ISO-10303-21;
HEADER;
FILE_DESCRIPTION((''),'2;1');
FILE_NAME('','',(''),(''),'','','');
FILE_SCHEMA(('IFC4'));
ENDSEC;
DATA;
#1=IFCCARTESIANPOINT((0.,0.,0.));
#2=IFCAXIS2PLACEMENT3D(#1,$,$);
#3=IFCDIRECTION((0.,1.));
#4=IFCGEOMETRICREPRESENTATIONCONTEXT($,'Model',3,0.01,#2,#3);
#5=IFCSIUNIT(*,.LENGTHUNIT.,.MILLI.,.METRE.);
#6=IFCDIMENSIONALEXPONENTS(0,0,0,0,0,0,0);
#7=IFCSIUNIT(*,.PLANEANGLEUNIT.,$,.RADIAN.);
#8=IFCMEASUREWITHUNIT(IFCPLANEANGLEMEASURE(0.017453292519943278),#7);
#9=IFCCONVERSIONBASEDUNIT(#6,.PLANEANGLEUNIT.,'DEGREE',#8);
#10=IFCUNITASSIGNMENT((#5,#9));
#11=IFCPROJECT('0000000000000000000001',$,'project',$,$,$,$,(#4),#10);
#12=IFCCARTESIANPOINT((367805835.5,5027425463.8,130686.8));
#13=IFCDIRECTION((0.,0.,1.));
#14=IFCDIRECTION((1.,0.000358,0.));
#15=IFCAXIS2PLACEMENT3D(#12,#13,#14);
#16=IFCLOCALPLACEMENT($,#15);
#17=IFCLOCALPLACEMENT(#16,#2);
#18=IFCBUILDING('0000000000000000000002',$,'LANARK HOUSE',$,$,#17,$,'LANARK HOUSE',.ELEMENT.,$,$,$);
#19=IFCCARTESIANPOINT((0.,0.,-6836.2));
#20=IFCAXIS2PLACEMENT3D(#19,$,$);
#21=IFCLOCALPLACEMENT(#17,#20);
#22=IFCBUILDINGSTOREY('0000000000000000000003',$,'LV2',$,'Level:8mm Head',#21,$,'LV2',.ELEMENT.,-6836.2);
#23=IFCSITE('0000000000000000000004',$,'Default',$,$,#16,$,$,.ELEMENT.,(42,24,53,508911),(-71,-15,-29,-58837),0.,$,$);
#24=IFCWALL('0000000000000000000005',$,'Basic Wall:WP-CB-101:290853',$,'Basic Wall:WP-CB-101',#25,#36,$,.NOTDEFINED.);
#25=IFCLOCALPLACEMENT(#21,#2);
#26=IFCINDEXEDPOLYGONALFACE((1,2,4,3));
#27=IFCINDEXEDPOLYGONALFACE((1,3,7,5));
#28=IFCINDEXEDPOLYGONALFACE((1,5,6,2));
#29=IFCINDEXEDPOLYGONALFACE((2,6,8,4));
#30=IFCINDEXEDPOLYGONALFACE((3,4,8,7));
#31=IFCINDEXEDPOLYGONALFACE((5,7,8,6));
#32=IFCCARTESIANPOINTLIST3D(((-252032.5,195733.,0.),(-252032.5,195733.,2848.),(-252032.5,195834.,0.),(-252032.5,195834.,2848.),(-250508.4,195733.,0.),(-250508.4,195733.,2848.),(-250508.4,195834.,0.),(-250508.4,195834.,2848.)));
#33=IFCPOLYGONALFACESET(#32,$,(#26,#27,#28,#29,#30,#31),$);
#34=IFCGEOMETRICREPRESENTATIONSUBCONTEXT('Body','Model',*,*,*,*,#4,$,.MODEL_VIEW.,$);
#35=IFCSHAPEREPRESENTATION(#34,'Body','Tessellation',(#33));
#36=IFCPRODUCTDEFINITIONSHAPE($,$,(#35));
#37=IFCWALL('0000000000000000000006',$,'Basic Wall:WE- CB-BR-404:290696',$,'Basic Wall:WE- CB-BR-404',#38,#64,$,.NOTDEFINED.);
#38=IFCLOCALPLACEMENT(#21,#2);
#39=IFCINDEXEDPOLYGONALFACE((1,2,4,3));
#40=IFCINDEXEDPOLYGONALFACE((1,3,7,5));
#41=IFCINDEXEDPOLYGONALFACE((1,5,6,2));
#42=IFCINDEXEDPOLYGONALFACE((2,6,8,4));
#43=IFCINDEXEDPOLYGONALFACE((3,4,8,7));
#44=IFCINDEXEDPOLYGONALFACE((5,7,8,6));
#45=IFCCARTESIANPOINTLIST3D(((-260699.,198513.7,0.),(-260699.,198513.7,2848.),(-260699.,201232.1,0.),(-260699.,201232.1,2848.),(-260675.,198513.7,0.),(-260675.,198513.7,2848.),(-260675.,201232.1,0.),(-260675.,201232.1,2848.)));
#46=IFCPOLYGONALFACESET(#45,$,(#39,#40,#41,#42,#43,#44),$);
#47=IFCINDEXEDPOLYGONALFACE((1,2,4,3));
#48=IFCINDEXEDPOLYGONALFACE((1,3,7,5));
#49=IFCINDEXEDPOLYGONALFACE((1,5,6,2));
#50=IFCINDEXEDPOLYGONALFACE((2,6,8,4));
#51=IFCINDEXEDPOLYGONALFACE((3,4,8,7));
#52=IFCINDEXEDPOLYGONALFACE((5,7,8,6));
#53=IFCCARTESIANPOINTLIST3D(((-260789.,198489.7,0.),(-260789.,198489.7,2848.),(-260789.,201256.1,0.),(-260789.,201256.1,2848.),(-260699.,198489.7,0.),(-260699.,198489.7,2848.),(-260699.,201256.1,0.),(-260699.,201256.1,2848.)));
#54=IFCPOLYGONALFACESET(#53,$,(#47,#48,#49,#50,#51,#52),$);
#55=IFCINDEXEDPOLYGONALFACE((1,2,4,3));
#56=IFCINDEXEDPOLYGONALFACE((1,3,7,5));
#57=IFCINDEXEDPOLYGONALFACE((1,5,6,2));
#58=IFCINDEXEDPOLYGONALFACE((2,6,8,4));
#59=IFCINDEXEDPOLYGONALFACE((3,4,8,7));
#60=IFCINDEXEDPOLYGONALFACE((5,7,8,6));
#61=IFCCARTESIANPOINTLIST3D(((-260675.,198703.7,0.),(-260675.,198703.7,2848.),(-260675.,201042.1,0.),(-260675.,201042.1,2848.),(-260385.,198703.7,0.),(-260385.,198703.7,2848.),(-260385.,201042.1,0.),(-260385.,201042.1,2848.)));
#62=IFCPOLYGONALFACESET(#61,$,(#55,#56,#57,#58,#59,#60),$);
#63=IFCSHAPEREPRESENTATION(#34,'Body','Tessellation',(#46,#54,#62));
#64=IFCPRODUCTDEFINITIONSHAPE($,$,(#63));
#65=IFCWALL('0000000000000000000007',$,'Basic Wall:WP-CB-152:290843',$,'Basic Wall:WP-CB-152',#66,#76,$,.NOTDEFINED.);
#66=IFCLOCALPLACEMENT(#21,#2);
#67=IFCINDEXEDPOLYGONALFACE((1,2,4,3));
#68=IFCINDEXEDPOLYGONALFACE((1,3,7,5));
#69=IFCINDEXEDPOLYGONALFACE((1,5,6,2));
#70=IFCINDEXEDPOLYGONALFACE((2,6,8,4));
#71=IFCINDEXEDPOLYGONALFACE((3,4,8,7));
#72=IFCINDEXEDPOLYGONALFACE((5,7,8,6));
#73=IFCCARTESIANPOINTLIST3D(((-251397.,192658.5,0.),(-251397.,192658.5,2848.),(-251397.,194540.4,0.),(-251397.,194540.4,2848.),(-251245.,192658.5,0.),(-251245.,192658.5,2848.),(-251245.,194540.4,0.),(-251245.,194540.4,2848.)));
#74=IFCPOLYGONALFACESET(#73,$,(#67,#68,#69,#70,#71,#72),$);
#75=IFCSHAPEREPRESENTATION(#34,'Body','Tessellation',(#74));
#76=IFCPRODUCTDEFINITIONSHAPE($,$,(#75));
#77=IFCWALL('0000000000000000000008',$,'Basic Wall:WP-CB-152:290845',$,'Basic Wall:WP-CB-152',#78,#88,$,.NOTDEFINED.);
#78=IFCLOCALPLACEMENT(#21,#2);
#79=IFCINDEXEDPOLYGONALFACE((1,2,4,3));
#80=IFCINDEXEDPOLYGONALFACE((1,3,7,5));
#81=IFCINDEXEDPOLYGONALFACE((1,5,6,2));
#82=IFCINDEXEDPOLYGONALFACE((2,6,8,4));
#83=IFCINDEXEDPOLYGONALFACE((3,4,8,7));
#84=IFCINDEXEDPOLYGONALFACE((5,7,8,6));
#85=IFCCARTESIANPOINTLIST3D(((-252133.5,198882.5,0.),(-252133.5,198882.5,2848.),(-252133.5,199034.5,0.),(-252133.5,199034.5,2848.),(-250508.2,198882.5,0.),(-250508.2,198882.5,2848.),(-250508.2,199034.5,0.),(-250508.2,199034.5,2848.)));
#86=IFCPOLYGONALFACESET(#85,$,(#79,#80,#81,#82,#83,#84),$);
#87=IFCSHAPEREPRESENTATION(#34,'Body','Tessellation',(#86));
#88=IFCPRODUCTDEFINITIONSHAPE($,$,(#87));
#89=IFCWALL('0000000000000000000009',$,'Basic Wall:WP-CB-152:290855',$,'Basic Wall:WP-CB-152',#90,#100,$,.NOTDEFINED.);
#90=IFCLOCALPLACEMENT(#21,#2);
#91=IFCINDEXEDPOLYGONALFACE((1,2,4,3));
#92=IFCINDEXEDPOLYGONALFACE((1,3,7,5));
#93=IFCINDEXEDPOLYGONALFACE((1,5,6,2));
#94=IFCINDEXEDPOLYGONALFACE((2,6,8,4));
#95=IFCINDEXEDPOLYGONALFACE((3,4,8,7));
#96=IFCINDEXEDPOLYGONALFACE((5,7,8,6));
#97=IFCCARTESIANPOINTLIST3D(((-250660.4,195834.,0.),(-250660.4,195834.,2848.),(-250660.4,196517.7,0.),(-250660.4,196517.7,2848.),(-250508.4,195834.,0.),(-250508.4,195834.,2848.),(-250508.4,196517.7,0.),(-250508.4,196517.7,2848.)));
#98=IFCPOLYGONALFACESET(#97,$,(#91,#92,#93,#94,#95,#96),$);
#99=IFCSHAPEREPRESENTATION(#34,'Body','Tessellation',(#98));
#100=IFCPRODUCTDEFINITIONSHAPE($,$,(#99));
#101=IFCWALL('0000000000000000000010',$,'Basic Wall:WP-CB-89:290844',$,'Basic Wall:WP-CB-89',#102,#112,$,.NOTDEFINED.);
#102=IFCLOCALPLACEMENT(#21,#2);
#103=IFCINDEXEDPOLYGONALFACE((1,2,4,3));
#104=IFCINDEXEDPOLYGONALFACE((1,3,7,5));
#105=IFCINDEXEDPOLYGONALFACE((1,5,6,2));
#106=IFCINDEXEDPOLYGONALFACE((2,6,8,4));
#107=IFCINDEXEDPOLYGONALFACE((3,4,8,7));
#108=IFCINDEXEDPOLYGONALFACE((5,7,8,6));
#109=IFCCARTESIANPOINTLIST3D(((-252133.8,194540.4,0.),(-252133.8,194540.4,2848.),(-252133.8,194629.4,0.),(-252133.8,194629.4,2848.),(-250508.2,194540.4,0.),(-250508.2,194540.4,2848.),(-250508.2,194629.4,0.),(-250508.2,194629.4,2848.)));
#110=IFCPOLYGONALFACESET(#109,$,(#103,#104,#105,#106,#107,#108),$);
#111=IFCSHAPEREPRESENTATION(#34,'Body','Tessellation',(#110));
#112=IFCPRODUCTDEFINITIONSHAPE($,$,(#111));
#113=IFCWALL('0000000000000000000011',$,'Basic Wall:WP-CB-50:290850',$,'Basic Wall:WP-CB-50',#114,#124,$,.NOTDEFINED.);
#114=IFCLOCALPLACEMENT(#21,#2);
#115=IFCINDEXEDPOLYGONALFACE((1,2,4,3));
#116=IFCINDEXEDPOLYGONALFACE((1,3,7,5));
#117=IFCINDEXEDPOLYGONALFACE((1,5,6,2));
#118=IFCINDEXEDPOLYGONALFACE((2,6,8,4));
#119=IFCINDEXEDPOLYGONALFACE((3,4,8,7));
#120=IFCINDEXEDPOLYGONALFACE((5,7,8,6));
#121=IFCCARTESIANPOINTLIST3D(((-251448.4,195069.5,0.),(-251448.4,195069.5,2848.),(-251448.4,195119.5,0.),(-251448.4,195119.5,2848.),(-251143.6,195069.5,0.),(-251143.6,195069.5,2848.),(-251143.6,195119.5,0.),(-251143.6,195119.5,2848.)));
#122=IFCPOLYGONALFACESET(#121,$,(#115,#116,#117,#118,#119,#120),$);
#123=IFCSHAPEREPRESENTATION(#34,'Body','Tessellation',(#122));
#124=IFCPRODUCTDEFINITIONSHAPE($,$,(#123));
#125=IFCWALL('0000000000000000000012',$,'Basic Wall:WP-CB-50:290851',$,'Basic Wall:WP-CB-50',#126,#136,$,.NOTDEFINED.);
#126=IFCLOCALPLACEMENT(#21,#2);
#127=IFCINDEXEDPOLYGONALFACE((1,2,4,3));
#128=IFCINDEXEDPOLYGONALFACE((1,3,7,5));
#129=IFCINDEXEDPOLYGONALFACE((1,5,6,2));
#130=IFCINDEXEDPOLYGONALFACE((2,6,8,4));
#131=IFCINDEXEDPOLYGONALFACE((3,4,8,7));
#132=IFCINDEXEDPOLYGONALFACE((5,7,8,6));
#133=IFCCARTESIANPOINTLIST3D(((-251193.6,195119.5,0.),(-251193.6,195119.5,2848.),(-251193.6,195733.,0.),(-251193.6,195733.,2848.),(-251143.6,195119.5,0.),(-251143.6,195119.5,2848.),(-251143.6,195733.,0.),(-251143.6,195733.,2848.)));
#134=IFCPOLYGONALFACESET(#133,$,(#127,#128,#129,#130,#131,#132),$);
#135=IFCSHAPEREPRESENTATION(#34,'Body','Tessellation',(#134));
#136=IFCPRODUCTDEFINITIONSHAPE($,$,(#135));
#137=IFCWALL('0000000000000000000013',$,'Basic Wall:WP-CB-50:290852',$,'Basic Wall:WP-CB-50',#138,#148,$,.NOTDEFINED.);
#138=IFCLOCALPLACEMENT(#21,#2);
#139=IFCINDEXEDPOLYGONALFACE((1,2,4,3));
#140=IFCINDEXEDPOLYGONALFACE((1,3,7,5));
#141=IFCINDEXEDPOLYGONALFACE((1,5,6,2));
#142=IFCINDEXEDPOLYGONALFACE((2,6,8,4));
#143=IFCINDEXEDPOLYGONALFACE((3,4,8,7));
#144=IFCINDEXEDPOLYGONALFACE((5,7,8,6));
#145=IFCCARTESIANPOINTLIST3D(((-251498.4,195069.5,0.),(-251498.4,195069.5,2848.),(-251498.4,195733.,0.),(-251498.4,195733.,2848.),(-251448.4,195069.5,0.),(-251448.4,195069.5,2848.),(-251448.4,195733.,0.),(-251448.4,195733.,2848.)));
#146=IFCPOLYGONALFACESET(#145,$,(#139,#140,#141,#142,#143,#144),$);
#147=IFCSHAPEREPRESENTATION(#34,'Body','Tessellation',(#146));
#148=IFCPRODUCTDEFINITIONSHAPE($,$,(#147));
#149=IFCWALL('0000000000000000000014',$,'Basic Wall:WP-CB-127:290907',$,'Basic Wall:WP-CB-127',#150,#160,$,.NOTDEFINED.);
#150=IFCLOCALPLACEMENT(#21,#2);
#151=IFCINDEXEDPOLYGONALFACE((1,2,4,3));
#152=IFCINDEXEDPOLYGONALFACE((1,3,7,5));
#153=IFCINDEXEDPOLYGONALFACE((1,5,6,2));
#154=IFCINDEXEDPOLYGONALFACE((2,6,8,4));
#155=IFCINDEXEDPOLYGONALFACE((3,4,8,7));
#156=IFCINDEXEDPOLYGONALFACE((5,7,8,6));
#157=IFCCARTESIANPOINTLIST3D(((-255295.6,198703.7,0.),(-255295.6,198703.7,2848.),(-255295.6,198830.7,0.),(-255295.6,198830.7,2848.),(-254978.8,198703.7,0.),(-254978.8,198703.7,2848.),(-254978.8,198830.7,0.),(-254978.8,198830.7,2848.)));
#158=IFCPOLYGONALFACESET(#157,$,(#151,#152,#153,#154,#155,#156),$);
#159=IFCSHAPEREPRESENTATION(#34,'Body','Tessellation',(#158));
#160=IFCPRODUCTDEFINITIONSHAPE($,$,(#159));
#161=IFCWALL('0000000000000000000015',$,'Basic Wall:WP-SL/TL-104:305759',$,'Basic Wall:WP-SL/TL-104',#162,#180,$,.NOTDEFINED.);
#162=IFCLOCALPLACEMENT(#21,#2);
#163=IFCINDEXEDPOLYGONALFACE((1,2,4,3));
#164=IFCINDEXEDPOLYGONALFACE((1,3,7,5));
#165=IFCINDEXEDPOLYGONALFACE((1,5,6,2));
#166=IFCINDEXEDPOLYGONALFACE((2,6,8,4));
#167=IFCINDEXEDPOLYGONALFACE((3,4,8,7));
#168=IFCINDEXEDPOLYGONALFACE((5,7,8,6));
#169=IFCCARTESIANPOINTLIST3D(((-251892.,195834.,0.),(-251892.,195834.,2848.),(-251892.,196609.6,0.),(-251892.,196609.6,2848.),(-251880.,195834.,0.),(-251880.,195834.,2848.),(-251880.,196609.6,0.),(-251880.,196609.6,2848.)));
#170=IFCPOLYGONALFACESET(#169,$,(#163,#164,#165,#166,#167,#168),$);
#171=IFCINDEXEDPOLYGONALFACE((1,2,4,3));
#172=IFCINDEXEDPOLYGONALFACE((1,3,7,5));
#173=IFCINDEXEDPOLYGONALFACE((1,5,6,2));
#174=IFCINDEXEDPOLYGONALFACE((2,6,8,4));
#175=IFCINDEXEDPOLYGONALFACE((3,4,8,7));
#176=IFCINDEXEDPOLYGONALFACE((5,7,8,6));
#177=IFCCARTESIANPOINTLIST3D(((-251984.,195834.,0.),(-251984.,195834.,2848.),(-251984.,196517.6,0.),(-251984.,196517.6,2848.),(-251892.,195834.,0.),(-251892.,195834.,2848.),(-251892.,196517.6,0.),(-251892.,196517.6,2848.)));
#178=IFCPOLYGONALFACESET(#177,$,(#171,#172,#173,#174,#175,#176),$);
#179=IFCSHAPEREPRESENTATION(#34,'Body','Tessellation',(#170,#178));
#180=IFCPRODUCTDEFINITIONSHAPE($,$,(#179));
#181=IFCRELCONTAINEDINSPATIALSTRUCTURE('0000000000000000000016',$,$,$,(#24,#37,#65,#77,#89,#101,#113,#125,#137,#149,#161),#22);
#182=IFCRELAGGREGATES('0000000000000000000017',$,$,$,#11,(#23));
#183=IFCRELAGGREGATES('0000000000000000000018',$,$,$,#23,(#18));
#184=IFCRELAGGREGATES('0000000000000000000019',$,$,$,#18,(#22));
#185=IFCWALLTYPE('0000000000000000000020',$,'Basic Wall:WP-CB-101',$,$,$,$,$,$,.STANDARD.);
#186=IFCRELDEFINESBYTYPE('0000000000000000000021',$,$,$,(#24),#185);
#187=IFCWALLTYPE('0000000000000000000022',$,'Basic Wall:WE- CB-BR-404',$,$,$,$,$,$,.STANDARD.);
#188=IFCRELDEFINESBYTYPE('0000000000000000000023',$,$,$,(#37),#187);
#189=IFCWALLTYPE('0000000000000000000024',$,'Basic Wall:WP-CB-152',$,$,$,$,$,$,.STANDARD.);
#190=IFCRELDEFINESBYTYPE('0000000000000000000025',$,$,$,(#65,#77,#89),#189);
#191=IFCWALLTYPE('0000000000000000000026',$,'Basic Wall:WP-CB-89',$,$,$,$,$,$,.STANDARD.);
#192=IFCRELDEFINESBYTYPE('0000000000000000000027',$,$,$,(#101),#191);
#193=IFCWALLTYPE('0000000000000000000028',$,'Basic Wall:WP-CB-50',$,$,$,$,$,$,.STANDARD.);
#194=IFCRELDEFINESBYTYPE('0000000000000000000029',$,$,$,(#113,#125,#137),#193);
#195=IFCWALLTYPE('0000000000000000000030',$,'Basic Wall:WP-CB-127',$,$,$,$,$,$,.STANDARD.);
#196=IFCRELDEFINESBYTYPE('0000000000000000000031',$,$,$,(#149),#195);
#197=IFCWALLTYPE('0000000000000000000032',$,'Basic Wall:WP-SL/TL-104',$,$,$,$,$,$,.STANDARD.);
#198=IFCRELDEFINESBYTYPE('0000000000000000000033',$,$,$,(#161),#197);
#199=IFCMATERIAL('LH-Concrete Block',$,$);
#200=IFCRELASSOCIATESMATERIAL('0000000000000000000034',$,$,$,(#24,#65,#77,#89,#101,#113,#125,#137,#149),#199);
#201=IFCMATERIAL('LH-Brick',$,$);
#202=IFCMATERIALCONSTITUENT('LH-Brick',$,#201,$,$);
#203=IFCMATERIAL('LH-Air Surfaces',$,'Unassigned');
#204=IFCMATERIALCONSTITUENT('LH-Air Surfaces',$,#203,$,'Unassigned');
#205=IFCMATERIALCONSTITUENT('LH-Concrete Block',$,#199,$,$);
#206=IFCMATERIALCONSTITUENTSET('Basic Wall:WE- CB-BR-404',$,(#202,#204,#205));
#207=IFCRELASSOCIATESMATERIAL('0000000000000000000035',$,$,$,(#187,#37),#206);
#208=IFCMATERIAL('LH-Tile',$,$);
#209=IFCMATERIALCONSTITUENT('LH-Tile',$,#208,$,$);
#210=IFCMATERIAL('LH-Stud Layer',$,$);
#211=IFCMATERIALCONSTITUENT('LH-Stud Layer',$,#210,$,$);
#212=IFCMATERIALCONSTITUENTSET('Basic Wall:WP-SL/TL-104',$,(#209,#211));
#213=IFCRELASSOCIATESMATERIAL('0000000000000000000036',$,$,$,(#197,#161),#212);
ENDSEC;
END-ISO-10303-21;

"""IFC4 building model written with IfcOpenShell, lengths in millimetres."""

from ifc_helpers import new_model, entity, si_unit, converted_unit, direction, frame, origin, place, context, subcontext, project, spatial, indexed_curve, outline, extrude, material, constituent, constituent_set, type_object, element, save


model = new_model("IFC4")

# Units and contexts
model_context = context("Model", 3, precision=0.01, world=origin(), true_north=direction((0.0, 1.0)))
body_context = subcontext(model_context, "Body", "Model", "MODEL_VIEW")
ifc_project = project(units=[si_unit("LENGTHUNIT", "METRE", prefix="MILLI"), converted_unit("PLANEANGLEUNIT", "DEGREE", entity("IfcPlaneAngleMeasure", 0.017453292519943278), si_unit("PLANEANGLEUNIT", "RADIAN"), dimensions=[0, 0, 0, 0, 0, 0, 0])], contexts=[model_context])

# Site, building, storey
site_placement = place(None, frame((367805835.5, 5027425463.8, 130686.8), z_axis=(0.0, 0.0, 1.0), x_axis=(1.0, 0.000358, 0.0)))
site = spatial("IfcSite", under=ifc_project, at=site_placement, Name="Default", CompositionType="ELEMENT", RefLatitude=(42, 24, 53, 508911), RefLongitude=(-71, -15, -29, -58837), RefElevation=0.0)
building_placement = place(site_placement, origin())
building = spatial("IfcBuilding", under=site, at=building_placement, Name="LANARK HOUSE", LongName="LANARK HOUSE", CompositionType="ELEMENT")
storey_placement = place(building_placement, frame((0.0, 0.0, -6836.2)))
storey = spatial("IfcBuildingStorey", under=building, at=storey_placement, Name="LV2", ObjectType="Level:8mm Head", LongName="LV2", CompositionType="ELEMENT", Elevation=-6836.2)

# Walls
ifc_material_1 = material(Name="LH-Brick")
ifc_material_2 = material(Name="LH-Air Surfaces", Category="Unassigned")
ifc_material_3 = material(Name="LH-Concrete Block")
wall_type_1 = type_object("IfcWallType", Name="Basic Wall:WP-CB-101", PredefinedType="STANDARD")
wall_1_placement = place(storey_placement, frame((-252032.5, 195783.5, 0.0)))
element("IfcWall", 1, at=wall_1_placement, inside=storey, type_object=wall_type_1, material=ifc_material_3, Name="Basic Wall:WP-CB-101:290853", ObjectType="Basic Wall:WP-CB-101", PredefinedType="NOTDEFINED", context=body_context, shape_type="SweptSolid", body=[
    extrude(outline(indexed_curve([(1524.1, 50.5), (0.0, 50.5), (0.0, -50.5), (1524.1, -50.5), (1524.1, 50.5)], self_intersect=False)), origin(), (0.0, 0.0, 1.0), 2848.0),
])
ifc_constituent_1 = constituent(ifc_material_1, Name="LH-Brick")
ifc_constituent_2 = constituent(ifc_material_2, Name="LH-Air Surfaces", Category="Unassigned")
ifc_constituent_3 = constituent(ifc_material_3, Name="LH-Concrete Block")
ifc_constituent_set_1 = constituent_set(constituents=[ifc_constituent_1, ifc_constituent_2, ifc_constituent_3], Name="Basic Wall:WE- CB-BR-404")
wall_type_2 = type_object("IfcWallType", Name="Basic Wall:WE- CB-BR-404", PredefinedType="STANDARD", material=ifc_constituent_set_1)
wall_2_placement = place(storey_placement, frame((-260587.0, 198703.7, 0.0), z_axis=(0.0, 0.0, 1.0), x_axis=(0.0, 1.0, 0.0)))
element("IfcWall", 2, at=wall_2_placement, inside=storey, type_object=wall_type_2, material=ifc_constituent_set_1, Name="Basic Wall:WE- CB-BR-404:290696", ObjectType="Basic Wall:WE- CB-BR-404", PredefinedType="NOTDEFINED", context=body_context, shape_type="SweptSolid", body=[
    extrude(outline(indexed_curve([(-1359.2, -12.0), (1359.2, -12.0), (1359.2, 12.0), (-1359.2, 12.0), (-1359.2, -12.0)], self_intersect=False)), frame((1169.2, 100.0, 0.0)), (0.0, 0.0, 1.0), 2848.0),
    extrude(outline(indexed_curve([(-45.0, -1383.2), (45.0, -1383.2), (45.0, 1383.2), (-45.0, 1383.2), (-45.0, -1383.2)], self_intersect=False)), frame((1169.2, 157.0, 0.0), z_axis=(0.0, 0.0, 1.0), x_axis=(0.0, -1.0, 0.0)), (0.0, 0.0, 1.0), 2848.0),
    extrude(outline(indexed_curve([(-145.0, -1169.2), (145.0, -1169.2), (145.0, 1169.2), (-145.0, 1169.2), (-145.0, -1169.2)], self_intersect=False)), frame((1169.2, -57.0, 0.0), z_axis=(0.0, 0.0, 1.0), x_axis=(0.0, 1.0, 0.0)), (0.0, 0.0, 1.0), 2848.0),
])
wall_type_3 = type_object("IfcWallType", Name="Basic Wall:WP-CB-152", PredefinedType="STANDARD")
wall_3_placement = place(storey_placement, frame((-251321.0, 194540.4, 0.0), z_axis=(0.0, 0.0, 1.0), x_axis=(0.0, -1.0, 0.0)))
element("IfcWall", 3, at=wall_3_placement, inside=storey, type_object=wall_type_3, material=ifc_material_3, Name="Basic Wall:WP-CB-152:290843", ObjectType="Basic Wall:WP-CB-152", PredefinedType="NOTDEFINED", context=body_context, shape_type="SweptSolid", body=[
    extrude(outline(indexed_curve([(1881.9, 76.0), (0.0, 76.0), (0.0, -76.0), (1881.9, -76.0), (1881.9, 76.0)], self_intersect=False)), origin(), (0.0, 0.0, 1.0), 2848.0),
])
wall_4_placement = place(storey_placement, frame((-252133.5, 198958.5, 0.0)))
element("IfcWall", 4, at=wall_4_placement, inside=storey, type_object=wall_type_3, material=ifc_material_3, Name="Basic Wall:WP-CB-152:290845", ObjectType="Basic Wall:WP-CB-152", PredefinedType="NOTDEFINED", context=body_context, shape_type="SweptSolid", body=[
    extrude(outline(indexed_curve([(1625.3, 76.0), (0.0, 76.0), (0.0, -76.0), (1625.3, -76.0), (1625.3, 76.0)], self_intersect=False)), origin(), (0.0, 0.0, 1.0), 2848.0),
])
wall_5_placement = place(storey_placement, frame((-250584.4, 196517.7, 0.0), z_axis=(0.0, 0.0, 1.0), x_axis=(0.0, -1.0, 0.0)))
element("IfcWall", 5, at=wall_5_placement, inside=storey, type_object=wall_type_3, material=ifc_material_3, Name="Basic Wall:WP-CB-152:290855", ObjectType="Basic Wall:WP-CB-152", PredefinedType="NOTDEFINED", context=body_context, shape_type="SweptSolid", body=[
    extrude(outline(indexed_curve([(683.7, 76.0), (0.0, 76.0), (0.0, -76.0), (683.7, -76.0), (683.7, 76.0)], self_intersect=False)), origin(), (0.0, 0.0, 1.0), 2848.0),
])
wall_type_4 = type_object("IfcWallType", Name="Basic Wall:WP-CB-89", PredefinedType="STANDARD")
wall_6_placement = place(storey_placement, frame((-252133.8, 194584.9, 0.0)))
element("IfcWall", 6, at=wall_6_placement, inside=storey, type_object=wall_type_4, material=ifc_material_3, Name="Basic Wall:WP-CB-89:290844", ObjectType="Basic Wall:WP-CB-89", PredefinedType="NOTDEFINED", context=body_context, shape_type="SweptSolid", body=[
    extrude(outline(indexed_curve([(1625.6, 44.5), (0.0, 44.5), (0.0, -44.5), (1625.6, -44.5), (1625.6, 44.5)], self_intersect=False)), origin(), (0.0, 0.0, 1.0), 2848.0),
])
wall_type_5 = type_object("IfcWallType", Name="Basic Wall:WP-CB-50", PredefinedType="STANDARD")
wall_7_placement = place(storey_placement, frame((-251143.6, 195094.5, 0.0), z_axis=(0.0, 0.0, 1.0), x_axis=(-1.0, 0.0, 0.0)))
element("IfcWall", 7, at=wall_7_placement, inside=storey, type_object=wall_type_5, material=ifc_material_3, Name="Basic Wall:WP-CB-50:290850", ObjectType="Basic Wall:WP-CB-50", PredefinedType="NOTDEFINED", context=body_context, shape_type="SweptSolid", body=[
    extrude(outline(indexed_curve([(304.8, 25.0), (0.0, 25.0), (0.0, -25.0), (304.8, -25.0), (304.8, 25.0)], self_intersect=False)), origin(), (0.0, 0.0, 1.0), 2848.0),
])
wall_8_placement = place(storey_placement, frame((-251168.6, 195733.0, 0.0), z_axis=(0.0, 0.0, 1.0), x_axis=(0.0, -1.0, 0.0)))
element("IfcWall", 8, at=wall_8_placement, inside=storey, type_object=wall_type_5, material=ifc_material_3, Name="Basic Wall:WP-CB-50:290851", ObjectType="Basic Wall:WP-CB-50", PredefinedType="NOTDEFINED", context=body_context, shape_type="SweptSolid", body=[
    extrude(outline(indexed_curve([(613.5, 25.0), (0.0, 25.0), (0.0, -25.0), (613.5, -25.0), (613.5, 25.0)], self_intersect=False)), origin(), (0.0, 0.0, 1.0), 2848.0),
])
wall_9_placement = place(storey_placement, frame((-251473.4, 195733.0, 0.0), z_axis=(0.0, 0.0, 1.0), x_axis=(0.0, -1.0, 0.0)))
element("IfcWall", 9, at=wall_9_placement, inside=storey, type_object=wall_type_5, material=ifc_material_3, Name="Basic Wall:WP-CB-50:290852", ObjectType="Basic Wall:WP-CB-50", PredefinedType="NOTDEFINED", context=body_context, shape_type="SweptSolid", body=[
    extrude(outline(indexed_curve([(663.5, 25.0), (0.0, 25.0), (0.0, -25.0), (663.5, -25.0), (663.5, 25.0)], self_intersect=False)), origin(), (0.0, 0.0, 1.0), 2848.0),
])
wall_type_6 = type_object("IfcWallType", Name="Basic Wall:WP-CB-127", PredefinedType="STANDARD")
wall_10_placement = place(storey_placement, frame((-254978.8, 198767.2, 0.0), z_axis=(0.0, 0.0, 1.0), x_axis=(-1.0, 0.0, 0.0)))
element("IfcWall", 10, at=wall_10_placement, inside=storey, type_object=wall_type_6, material=ifc_material_3, Name="Basic Wall:WP-CB-127:290907", ObjectType="Basic Wall:WP-CB-127", PredefinedType="NOTDEFINED", context=body_context, shape_type="SweptSolid", body=[
    extrude(outline(indexed_curve([(316.8, 63.5), (0.0, 63.5), (0.0, -63.5), (316.8, -63.5), (316.8, 63.5)], self_intersect=False)), origin(), (0.0, 0.0, 1.0), 2848.0),
])
ifc_material_4 = material(Name="LH-Tile")
ifc_constituent_4 = constituent(ifc_material_4, Name="LH-Tile")
ifc_material_5 = material(Name="LH-Stud Layer")
ifc_constituent_5 = constituent(ifc_material_5, Name="LH-Stud Layer")
ifc_constituent_set_2 = constituent_set(constituents=[ifc_constituent_4, ifc_constituent_5], Name="Basic Wall:WP-SL/TL-104")
wall_type_7 = type_object("IfcWallType", Name="Basic Wall:WP-SL/TL-104", PredefinedType="STANDARD", material=ifc_constituent_set_2)
wall_11_placement = place(storey_placement, frame((-251932.0, 196517.6, 0.0), z_axis=(0.0, 0.0, 1.0), x_axis=(0.0, -1.0, 0.0)))
element("IfcWall", 11, at=wall_11_placement, inside=storey, type_object=wall_type_7, material=ifc_constituent_set_2, Name="Basic Wall:WP-SL/TL-104:305759", ObjectType="Basic Wall:WP-SL/TL-104", PredefinedType="NOTDEFINED", context=body_context, shape_type="SweptSolid", body=[
    extrude(outline(indexed_curve([(-6.0, -387.8), (6.0, -387.8), (6.0, 387.8), (-6.0, 387.8), (-6.0, -387.8)], self_intersect=False)), frame((295.8, 46.0, 0.0), z_axis=(0.0, 0.0, 1.0), x_axis=(0.0, -1.0, 0.0)), (0.0, 0.0, 1.0), 2848.0),
    extrude(outline(indexed_curve([(-46.0, -341.8), (46.0, -341.8), (46.0, 341.8), (-46.0, 341.8), (-46.0, -341.8)], self_intersect=False)), frame((341.8, -6.0, 0.0), z_axis=(0.0, 0.0, 1.0), x_axis=(0.0, 1.0, 0.0)), (0.0, 0.0, 1.0), 2848.0),
])

save(model, "model.ifc")
